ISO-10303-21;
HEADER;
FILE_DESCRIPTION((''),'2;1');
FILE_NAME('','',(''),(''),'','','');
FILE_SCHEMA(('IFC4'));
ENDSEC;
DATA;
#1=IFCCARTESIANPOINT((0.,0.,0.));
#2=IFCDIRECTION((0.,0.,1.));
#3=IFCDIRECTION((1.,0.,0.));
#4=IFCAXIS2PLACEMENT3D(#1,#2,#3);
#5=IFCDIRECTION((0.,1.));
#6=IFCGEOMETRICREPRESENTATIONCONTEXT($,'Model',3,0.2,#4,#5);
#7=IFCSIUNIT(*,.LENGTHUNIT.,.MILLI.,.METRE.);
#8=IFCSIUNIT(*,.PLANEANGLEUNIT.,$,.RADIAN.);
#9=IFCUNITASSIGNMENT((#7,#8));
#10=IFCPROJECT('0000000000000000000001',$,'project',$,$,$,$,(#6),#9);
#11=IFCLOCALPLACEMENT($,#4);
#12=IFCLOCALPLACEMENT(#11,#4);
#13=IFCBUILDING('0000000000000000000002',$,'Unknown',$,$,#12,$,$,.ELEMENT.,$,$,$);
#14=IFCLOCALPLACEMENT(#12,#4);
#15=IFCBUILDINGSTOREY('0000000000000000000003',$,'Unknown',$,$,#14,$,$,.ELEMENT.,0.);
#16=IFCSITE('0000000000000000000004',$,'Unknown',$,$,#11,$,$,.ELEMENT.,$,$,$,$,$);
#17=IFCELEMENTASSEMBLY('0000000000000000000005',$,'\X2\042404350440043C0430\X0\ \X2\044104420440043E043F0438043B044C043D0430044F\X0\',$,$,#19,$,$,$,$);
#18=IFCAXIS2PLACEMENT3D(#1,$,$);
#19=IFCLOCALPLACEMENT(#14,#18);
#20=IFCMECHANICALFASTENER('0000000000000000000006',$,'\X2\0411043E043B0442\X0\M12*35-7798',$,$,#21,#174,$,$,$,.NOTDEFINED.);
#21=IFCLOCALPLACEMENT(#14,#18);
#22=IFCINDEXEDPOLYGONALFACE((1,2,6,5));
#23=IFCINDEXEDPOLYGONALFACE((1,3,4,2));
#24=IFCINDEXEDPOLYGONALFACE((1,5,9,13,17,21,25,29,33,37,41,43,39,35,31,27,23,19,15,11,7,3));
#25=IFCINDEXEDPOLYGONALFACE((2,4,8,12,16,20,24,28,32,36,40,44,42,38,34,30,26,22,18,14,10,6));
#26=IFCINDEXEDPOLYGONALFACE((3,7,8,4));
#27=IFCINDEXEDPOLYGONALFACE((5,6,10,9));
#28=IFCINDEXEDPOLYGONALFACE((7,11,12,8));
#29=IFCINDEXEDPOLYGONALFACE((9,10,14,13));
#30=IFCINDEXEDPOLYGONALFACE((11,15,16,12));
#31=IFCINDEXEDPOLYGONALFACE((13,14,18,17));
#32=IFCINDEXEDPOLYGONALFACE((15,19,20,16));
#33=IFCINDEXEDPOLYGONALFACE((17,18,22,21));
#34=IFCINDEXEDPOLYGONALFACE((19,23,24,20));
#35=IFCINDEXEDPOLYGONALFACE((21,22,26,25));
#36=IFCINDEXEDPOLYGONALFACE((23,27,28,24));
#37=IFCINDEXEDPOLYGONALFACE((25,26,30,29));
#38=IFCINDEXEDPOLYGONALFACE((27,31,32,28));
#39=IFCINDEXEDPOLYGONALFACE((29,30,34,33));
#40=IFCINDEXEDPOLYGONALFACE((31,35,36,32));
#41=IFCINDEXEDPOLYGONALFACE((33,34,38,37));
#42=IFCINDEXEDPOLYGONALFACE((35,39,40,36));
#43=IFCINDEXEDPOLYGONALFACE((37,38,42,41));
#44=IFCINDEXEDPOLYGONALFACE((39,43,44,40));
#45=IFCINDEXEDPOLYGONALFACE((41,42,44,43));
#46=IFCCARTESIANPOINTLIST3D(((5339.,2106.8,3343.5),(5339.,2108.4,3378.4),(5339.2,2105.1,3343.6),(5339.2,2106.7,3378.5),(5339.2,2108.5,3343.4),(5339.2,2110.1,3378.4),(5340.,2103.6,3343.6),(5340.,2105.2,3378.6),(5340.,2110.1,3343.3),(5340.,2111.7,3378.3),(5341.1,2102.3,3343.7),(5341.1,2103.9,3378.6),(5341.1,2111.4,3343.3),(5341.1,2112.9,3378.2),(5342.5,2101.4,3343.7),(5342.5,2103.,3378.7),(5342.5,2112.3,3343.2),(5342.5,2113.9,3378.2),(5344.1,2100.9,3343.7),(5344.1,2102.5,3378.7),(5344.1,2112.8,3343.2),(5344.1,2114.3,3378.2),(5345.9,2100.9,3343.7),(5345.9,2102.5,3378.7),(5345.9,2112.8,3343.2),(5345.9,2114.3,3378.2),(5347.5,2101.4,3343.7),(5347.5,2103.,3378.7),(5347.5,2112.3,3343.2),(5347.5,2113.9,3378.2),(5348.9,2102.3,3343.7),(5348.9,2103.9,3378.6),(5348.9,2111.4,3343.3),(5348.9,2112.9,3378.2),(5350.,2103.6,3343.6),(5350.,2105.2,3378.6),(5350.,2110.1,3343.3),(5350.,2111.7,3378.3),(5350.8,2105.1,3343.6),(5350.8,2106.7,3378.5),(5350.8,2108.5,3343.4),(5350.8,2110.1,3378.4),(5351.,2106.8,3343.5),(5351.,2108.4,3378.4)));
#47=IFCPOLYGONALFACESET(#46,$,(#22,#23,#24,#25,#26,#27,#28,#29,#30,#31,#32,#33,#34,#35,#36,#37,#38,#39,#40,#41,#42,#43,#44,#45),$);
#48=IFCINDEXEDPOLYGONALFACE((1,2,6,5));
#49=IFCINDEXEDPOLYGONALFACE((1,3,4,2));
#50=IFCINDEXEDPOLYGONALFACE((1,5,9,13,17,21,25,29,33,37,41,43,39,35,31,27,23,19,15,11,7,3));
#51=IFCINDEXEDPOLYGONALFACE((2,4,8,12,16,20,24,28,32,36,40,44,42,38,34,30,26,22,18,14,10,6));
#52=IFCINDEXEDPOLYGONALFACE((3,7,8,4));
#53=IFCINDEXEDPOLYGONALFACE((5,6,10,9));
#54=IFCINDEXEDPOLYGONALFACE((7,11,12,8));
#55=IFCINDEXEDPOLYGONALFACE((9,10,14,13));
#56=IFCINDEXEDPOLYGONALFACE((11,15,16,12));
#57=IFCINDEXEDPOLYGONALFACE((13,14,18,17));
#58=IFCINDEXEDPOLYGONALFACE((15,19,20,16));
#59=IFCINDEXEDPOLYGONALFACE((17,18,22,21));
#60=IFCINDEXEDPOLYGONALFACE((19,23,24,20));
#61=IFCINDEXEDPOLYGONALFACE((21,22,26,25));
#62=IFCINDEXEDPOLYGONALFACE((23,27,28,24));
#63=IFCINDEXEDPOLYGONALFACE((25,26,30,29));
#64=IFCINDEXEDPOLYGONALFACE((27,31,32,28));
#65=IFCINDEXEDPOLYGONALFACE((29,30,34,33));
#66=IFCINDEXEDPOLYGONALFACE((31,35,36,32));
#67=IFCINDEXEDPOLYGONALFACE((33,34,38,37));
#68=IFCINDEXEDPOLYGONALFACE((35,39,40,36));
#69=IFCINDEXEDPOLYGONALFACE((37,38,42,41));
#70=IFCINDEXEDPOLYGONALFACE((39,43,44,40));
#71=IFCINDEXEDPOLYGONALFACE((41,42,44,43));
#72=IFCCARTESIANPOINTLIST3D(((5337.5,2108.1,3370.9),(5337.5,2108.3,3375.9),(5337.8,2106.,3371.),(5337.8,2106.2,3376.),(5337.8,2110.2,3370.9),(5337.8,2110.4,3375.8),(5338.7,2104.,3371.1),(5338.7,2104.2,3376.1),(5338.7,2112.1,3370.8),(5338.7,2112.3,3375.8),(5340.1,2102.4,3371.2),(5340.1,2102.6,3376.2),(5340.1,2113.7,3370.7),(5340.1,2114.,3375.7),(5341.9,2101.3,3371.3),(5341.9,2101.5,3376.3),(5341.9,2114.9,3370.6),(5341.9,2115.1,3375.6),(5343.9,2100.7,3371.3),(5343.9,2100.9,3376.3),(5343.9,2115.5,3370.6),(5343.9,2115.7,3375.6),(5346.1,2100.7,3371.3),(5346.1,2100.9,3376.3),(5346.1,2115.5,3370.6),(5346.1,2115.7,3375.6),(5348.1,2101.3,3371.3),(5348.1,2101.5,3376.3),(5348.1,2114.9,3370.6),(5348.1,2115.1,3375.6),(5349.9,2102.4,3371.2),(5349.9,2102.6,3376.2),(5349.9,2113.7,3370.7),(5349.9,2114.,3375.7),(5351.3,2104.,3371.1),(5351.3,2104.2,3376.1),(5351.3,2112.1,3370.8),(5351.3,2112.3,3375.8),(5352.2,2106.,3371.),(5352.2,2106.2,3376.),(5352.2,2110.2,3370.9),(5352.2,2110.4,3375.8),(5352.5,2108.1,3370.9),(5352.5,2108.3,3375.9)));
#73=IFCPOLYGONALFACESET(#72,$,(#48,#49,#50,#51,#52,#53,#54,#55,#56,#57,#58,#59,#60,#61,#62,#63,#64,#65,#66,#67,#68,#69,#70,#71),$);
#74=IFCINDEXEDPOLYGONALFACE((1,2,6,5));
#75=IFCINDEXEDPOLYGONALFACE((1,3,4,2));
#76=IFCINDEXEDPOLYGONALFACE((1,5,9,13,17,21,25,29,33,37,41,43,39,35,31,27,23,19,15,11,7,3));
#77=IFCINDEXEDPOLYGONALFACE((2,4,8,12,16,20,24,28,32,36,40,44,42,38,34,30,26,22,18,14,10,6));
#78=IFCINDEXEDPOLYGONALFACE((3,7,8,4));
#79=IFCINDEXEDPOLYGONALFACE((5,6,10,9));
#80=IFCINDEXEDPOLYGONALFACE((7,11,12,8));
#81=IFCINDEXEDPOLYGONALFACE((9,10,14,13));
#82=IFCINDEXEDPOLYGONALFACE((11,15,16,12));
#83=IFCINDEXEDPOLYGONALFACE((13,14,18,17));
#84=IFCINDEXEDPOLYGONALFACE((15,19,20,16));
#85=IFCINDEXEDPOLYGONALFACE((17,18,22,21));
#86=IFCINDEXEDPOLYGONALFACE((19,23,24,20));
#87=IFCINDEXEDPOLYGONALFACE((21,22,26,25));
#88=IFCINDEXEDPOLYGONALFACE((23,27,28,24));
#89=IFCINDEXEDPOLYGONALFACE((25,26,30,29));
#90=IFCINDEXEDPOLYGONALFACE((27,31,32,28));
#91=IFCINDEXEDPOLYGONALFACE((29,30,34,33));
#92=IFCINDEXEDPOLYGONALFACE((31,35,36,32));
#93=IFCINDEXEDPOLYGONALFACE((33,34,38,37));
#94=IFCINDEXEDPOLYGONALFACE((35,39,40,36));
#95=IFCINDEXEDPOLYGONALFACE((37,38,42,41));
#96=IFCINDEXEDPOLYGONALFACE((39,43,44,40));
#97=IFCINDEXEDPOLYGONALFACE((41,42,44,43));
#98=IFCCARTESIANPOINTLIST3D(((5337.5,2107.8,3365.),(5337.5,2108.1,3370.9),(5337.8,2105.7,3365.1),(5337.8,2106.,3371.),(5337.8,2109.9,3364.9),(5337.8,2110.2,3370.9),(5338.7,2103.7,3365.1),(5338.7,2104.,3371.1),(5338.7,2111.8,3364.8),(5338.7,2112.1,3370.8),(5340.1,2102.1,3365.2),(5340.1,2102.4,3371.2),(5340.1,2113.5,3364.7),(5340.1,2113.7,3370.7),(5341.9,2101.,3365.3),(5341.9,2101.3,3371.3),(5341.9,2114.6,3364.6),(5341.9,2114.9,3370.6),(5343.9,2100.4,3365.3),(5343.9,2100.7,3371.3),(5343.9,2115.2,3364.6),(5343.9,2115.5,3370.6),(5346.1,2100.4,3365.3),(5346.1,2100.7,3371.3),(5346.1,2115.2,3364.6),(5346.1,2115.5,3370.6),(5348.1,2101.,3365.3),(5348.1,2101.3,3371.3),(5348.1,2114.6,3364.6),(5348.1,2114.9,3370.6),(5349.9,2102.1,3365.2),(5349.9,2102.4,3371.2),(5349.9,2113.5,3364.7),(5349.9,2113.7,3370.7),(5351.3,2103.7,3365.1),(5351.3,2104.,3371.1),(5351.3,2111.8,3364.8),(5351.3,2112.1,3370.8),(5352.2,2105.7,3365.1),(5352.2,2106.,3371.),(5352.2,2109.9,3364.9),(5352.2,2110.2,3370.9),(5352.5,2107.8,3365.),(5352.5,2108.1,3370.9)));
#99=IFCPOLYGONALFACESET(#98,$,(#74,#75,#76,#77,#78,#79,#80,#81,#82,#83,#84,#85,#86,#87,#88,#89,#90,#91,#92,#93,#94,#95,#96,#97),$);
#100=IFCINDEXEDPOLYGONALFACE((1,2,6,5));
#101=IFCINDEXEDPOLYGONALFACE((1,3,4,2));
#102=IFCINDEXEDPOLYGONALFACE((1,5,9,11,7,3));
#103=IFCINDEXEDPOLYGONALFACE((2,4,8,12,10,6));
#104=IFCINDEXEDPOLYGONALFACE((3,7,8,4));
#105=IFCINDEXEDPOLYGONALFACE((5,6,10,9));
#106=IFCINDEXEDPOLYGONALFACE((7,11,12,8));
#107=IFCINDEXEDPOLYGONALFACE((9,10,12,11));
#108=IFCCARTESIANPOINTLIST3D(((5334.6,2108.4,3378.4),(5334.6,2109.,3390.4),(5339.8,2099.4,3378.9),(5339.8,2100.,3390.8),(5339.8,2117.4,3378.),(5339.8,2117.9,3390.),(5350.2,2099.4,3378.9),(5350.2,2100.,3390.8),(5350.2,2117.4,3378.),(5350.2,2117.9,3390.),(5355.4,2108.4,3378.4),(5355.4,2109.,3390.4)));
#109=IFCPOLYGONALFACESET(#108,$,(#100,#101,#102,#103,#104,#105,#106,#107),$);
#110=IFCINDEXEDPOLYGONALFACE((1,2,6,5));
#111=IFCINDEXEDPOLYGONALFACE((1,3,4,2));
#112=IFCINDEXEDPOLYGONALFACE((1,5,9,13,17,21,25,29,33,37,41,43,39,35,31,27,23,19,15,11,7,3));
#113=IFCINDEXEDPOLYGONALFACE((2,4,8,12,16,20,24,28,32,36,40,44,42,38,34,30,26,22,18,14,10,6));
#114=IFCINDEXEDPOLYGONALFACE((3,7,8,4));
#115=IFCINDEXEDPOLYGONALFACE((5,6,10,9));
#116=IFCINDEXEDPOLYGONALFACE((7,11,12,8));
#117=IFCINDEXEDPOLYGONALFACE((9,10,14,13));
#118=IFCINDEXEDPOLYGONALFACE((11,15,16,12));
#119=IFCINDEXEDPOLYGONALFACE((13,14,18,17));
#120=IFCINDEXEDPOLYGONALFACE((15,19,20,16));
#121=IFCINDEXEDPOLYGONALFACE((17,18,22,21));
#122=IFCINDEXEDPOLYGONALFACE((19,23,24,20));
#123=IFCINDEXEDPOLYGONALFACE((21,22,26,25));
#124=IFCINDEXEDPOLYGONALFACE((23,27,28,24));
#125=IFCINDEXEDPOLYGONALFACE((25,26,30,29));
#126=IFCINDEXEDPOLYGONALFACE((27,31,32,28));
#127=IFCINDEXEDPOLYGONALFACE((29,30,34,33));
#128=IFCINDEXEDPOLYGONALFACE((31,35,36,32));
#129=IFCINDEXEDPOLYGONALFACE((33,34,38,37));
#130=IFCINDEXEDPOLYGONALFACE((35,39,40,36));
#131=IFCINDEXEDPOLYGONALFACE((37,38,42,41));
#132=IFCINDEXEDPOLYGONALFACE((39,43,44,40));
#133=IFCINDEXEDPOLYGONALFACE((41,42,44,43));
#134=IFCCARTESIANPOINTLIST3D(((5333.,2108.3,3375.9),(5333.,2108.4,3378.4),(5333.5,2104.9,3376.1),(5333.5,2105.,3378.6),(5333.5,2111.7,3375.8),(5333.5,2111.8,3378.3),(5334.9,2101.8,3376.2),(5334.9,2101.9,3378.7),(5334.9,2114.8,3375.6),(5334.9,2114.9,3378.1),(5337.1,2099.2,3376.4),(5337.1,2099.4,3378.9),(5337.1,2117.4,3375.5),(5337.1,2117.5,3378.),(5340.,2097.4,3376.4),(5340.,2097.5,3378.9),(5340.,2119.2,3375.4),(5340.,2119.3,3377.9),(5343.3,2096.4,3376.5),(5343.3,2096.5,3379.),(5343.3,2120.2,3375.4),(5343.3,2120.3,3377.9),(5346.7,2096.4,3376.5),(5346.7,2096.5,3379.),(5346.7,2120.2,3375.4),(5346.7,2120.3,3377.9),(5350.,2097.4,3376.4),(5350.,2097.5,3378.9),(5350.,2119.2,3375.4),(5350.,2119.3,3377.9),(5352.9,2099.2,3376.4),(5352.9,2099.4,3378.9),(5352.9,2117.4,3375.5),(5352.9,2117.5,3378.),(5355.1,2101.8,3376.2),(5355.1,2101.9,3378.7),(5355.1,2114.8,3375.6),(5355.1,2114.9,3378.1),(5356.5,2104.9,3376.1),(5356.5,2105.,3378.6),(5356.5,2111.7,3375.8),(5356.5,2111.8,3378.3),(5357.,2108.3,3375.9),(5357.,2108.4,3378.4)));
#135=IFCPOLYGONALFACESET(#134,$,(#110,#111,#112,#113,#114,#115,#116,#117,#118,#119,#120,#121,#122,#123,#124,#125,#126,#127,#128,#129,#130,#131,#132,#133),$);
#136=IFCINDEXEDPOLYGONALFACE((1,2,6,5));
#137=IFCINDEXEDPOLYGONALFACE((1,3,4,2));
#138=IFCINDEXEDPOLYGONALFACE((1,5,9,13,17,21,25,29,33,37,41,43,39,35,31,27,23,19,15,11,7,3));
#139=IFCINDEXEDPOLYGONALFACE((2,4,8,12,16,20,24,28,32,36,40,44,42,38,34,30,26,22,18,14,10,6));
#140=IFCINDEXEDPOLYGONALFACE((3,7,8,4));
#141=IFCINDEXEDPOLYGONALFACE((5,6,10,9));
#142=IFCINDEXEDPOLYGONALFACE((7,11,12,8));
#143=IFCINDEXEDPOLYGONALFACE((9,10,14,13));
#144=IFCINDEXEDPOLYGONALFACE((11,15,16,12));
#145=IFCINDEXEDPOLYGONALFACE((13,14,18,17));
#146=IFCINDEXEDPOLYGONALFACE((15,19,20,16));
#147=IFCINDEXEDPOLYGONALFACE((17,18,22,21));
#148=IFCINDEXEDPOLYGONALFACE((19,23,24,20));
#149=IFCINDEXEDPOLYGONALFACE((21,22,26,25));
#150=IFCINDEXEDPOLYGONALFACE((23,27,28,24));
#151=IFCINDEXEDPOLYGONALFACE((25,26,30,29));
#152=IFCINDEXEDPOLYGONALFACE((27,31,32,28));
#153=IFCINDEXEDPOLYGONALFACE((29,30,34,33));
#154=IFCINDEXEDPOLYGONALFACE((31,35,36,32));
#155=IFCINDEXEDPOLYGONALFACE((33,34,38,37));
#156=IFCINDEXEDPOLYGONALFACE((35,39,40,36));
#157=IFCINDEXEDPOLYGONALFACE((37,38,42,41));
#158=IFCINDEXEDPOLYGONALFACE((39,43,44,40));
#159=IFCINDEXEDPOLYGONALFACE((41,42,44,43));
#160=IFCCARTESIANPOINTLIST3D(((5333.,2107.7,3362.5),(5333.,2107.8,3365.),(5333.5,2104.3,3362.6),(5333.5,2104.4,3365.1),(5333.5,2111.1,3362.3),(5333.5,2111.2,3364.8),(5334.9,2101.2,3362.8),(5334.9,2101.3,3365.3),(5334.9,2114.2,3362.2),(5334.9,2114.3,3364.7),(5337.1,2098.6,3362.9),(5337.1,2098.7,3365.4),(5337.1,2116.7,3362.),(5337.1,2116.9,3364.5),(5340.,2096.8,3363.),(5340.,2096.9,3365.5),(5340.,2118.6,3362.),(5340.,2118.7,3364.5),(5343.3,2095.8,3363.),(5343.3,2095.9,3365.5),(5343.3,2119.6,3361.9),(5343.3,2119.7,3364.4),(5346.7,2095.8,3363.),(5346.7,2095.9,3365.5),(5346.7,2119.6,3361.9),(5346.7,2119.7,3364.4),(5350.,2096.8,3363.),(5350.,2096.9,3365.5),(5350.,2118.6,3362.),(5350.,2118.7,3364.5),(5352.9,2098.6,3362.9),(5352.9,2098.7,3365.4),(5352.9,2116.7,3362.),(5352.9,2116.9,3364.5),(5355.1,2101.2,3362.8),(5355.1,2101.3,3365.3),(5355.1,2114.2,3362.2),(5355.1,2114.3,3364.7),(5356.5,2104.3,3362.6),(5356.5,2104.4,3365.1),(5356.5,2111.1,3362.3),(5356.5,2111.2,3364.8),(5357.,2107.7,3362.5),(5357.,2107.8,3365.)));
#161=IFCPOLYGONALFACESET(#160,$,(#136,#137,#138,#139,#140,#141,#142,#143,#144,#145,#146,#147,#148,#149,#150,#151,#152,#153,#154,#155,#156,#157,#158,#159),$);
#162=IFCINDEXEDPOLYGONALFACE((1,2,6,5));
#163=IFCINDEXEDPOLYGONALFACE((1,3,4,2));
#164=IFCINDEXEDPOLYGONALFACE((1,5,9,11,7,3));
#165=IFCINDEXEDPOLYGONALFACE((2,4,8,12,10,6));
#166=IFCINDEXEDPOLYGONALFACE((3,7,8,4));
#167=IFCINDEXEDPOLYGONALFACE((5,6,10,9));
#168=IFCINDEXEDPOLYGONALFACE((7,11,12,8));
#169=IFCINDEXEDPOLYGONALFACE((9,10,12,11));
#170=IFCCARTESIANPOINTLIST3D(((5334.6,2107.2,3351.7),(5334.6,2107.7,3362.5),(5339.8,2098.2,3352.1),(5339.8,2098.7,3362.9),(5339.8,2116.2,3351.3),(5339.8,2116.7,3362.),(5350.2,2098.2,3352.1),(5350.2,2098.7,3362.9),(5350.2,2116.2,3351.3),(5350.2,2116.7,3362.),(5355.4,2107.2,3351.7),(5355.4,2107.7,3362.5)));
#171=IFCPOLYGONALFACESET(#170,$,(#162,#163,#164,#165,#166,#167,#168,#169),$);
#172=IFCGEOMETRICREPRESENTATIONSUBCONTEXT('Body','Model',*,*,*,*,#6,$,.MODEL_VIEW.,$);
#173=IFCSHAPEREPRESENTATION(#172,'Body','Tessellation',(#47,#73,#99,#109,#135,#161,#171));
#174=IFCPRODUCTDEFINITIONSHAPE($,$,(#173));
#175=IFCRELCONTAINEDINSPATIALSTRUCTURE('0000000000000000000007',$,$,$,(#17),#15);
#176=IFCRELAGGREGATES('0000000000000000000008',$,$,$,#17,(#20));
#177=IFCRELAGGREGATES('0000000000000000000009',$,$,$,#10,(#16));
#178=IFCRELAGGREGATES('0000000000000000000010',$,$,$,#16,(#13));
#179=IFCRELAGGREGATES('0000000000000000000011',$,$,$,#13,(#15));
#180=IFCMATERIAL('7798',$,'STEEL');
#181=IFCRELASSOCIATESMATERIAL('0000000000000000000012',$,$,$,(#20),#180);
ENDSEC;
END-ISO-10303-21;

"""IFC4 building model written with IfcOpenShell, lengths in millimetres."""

from ifc_helpers import new_model, si_unit, direction, frame, origin_with_axes, place, context, subcontext, project, spatial, line, arc, indexed_curve, outline, extrude, source, transform, mapped, material, element, aggregate, save


model = new_model("IFC4")

# Units and contexts
model_context = context("Model", 3, precision=0.2, world=origin_with_axes(), true_north=direction((0.0, 1.0)))
body_context = subcontext(model_context, "Body", "Model", "MODEL_VIEW")
ifc_project = project(units=[si_unit("LENGTHUNIT", "METRE", prefix="MILLI"), si_unit("PLANEANGLEUNIT", "RADIAN")], contexts=[model_context])

# Site, building, storey
site_placement = place(None, origin_with_axes())
site = spatial("IfcSite", under=ifc_project, at=site_placement, Name="Unknown", CompositionType="ELEMENT")
building_placement = place(site_placement, origin_with_axes())
building = spatial("IfcBuilding", under=site, at=building_placement, Name="Unknown", CompositionType="ELEMENT")
storey_placement = place(building_placement, origin_with_axes())
storey = spatial("IfcBuildingStorey", under=building, at=storey_placement, Name="Unknown", CompositionType="ELEMENT", Elevation=0.0)

# Element assembly
assembly_1_placement = place(storey_placement, frame((5400.0, 88.6, 3426.7), z_axis=(1.0, 0.0, 0.0), x_axis=(0.0, 0.998969, -0.045408)))
assembly_1 = element("IfcElementAssembly", 1, at=assembly_1_placement, inside=storey, Name="Ферма стропильная")

# Mechanical fastener
ifc_material_1 = material(Name="7798", Category="STEEL")
shared_shape_1 = source(origin_with_axes(), body_context, "Body", "SweptSolid", [
    extrude(outline(indexed_curve([(6.0, 0.0), (0.0, 6.0), (-6.0, 0.0), (0.0, -6.0)], segments=[arc(1, 2, 3), arc(3, 4, 1)])), frame((0.0, 0.0, 7.5), z_axis=(0.0, 0.0, -1.0), x_axis=(0.0, 1.0, 0.0)), (0.0, 0.0, 1.0), 35.0),
    extrude(outline(indexed_curve([(7.5, 0.0), (0.0, 7.5), (-7.5, 0.0), (0.0, -7.5)], segments=[arc(1, 2, 3), arc(3, 4, 1)])), frame((0.0, 0.0, 5.0), z_axis=(0.0, 0.0, -1.0), x_axis=(0.0, 1.0, 0.0)), (0.0, 0.0, 1.0), 5.0),
    extrude(outline(indexed_curve([(7.5, 0.0), (0.0, 7.5), (-7.5, 0.0), (0.0, -7.5)], segments=[arc(1, 2, 3), arc(3, 4, 1)])), frame((0.0, 0.0, 0.0), z_axis=(0.0, 0.0, -1.0), x_axis=(0.0, 1.0, 0.0)), (0.0, 0.0, 1.0), 6.0),
    extrude(outline(indexed_curve([(10.4, 0.0), (5.2, 9.0), (-5.2, 9.0), (-10.4, 0.0), (-5.2, -9.0), (5.2, -9.0)], segments=[line(1, 2, 3, 4, 5, 6, 1)])), frame((0.0, 0.0, 19.5), z_axis=(0.0, 0.0, -1.0), x_axis=(0.0, 1.0, 0.0)), (0.0, 0.0, 1.0), 12.0),
    extrude(outline(indexed_curve([(12.0, 0.0), (0.0, 12.0), (-12.0, 0.0), (0.0, -12.0)], segments=[arc(1, 2, 3), arc(3, 4, 1)])), frame((0.0, 0.0, 7.5), z_axis=(0.0, 0.0, -1.0), x_axis=(0.0, 1.0, 0.0)), (0.0, 0.0, 1.0), 2.5),
    extrude(outline(indexed_curve([(12.0, 0.0), (0.0, 12.0), (-12.0, 0.0), (0.0, -12.0)], segments=[arc(1, 2, 3), arc(3, 4, 1)])), frame((0.0, 0.0, -6.0), z_axis=(0.0, 0.0, -1.0), x_axis=(0.0, 1.0, 0.0)), (0.0, 0.0, 1.0), 2.5),
    extrude(outline(indexed_curve([(10.4, 0.0), (5.2, 9.0), (-5.2, 9.0), (-10.4, 0.0), (-5.2, -9.0), (5.2, -9.0)], segments=[line(1, 2, 3, 4, 5, 6, 1)])), frame((0.0, 0.0, -8.5), z_axis=(0.0, 0.0, -1.0), x_axis=(0.0, 1.0, 0.0)), (0.0, 0.0, 1.0), 10.8),
])
mechanical_fastener_1_placement = place(assembly_1_placement, frame((2019.9, 36.0, -55.0), z_axis=(0.0, 1.0, 0.0), x_axis=(1.0, 0.0, 0.0)))
mechanical_fastener_1 = element("IfcMechanicalFastener", 2, at=mechanical_fastener_1_placement, material=ifc_material_1, Name="БолтM12*35-7798", PredefinedType="NOTDEFINED", context=body_context, shape_type="MappedRepresentation", body=[
    mapped(shared_shape_1, transform((0.0, 0.0, 0.0))),
])
aggregate(assembly_1, [mechanical_fastener_1])

save(model, "model.ifc")
